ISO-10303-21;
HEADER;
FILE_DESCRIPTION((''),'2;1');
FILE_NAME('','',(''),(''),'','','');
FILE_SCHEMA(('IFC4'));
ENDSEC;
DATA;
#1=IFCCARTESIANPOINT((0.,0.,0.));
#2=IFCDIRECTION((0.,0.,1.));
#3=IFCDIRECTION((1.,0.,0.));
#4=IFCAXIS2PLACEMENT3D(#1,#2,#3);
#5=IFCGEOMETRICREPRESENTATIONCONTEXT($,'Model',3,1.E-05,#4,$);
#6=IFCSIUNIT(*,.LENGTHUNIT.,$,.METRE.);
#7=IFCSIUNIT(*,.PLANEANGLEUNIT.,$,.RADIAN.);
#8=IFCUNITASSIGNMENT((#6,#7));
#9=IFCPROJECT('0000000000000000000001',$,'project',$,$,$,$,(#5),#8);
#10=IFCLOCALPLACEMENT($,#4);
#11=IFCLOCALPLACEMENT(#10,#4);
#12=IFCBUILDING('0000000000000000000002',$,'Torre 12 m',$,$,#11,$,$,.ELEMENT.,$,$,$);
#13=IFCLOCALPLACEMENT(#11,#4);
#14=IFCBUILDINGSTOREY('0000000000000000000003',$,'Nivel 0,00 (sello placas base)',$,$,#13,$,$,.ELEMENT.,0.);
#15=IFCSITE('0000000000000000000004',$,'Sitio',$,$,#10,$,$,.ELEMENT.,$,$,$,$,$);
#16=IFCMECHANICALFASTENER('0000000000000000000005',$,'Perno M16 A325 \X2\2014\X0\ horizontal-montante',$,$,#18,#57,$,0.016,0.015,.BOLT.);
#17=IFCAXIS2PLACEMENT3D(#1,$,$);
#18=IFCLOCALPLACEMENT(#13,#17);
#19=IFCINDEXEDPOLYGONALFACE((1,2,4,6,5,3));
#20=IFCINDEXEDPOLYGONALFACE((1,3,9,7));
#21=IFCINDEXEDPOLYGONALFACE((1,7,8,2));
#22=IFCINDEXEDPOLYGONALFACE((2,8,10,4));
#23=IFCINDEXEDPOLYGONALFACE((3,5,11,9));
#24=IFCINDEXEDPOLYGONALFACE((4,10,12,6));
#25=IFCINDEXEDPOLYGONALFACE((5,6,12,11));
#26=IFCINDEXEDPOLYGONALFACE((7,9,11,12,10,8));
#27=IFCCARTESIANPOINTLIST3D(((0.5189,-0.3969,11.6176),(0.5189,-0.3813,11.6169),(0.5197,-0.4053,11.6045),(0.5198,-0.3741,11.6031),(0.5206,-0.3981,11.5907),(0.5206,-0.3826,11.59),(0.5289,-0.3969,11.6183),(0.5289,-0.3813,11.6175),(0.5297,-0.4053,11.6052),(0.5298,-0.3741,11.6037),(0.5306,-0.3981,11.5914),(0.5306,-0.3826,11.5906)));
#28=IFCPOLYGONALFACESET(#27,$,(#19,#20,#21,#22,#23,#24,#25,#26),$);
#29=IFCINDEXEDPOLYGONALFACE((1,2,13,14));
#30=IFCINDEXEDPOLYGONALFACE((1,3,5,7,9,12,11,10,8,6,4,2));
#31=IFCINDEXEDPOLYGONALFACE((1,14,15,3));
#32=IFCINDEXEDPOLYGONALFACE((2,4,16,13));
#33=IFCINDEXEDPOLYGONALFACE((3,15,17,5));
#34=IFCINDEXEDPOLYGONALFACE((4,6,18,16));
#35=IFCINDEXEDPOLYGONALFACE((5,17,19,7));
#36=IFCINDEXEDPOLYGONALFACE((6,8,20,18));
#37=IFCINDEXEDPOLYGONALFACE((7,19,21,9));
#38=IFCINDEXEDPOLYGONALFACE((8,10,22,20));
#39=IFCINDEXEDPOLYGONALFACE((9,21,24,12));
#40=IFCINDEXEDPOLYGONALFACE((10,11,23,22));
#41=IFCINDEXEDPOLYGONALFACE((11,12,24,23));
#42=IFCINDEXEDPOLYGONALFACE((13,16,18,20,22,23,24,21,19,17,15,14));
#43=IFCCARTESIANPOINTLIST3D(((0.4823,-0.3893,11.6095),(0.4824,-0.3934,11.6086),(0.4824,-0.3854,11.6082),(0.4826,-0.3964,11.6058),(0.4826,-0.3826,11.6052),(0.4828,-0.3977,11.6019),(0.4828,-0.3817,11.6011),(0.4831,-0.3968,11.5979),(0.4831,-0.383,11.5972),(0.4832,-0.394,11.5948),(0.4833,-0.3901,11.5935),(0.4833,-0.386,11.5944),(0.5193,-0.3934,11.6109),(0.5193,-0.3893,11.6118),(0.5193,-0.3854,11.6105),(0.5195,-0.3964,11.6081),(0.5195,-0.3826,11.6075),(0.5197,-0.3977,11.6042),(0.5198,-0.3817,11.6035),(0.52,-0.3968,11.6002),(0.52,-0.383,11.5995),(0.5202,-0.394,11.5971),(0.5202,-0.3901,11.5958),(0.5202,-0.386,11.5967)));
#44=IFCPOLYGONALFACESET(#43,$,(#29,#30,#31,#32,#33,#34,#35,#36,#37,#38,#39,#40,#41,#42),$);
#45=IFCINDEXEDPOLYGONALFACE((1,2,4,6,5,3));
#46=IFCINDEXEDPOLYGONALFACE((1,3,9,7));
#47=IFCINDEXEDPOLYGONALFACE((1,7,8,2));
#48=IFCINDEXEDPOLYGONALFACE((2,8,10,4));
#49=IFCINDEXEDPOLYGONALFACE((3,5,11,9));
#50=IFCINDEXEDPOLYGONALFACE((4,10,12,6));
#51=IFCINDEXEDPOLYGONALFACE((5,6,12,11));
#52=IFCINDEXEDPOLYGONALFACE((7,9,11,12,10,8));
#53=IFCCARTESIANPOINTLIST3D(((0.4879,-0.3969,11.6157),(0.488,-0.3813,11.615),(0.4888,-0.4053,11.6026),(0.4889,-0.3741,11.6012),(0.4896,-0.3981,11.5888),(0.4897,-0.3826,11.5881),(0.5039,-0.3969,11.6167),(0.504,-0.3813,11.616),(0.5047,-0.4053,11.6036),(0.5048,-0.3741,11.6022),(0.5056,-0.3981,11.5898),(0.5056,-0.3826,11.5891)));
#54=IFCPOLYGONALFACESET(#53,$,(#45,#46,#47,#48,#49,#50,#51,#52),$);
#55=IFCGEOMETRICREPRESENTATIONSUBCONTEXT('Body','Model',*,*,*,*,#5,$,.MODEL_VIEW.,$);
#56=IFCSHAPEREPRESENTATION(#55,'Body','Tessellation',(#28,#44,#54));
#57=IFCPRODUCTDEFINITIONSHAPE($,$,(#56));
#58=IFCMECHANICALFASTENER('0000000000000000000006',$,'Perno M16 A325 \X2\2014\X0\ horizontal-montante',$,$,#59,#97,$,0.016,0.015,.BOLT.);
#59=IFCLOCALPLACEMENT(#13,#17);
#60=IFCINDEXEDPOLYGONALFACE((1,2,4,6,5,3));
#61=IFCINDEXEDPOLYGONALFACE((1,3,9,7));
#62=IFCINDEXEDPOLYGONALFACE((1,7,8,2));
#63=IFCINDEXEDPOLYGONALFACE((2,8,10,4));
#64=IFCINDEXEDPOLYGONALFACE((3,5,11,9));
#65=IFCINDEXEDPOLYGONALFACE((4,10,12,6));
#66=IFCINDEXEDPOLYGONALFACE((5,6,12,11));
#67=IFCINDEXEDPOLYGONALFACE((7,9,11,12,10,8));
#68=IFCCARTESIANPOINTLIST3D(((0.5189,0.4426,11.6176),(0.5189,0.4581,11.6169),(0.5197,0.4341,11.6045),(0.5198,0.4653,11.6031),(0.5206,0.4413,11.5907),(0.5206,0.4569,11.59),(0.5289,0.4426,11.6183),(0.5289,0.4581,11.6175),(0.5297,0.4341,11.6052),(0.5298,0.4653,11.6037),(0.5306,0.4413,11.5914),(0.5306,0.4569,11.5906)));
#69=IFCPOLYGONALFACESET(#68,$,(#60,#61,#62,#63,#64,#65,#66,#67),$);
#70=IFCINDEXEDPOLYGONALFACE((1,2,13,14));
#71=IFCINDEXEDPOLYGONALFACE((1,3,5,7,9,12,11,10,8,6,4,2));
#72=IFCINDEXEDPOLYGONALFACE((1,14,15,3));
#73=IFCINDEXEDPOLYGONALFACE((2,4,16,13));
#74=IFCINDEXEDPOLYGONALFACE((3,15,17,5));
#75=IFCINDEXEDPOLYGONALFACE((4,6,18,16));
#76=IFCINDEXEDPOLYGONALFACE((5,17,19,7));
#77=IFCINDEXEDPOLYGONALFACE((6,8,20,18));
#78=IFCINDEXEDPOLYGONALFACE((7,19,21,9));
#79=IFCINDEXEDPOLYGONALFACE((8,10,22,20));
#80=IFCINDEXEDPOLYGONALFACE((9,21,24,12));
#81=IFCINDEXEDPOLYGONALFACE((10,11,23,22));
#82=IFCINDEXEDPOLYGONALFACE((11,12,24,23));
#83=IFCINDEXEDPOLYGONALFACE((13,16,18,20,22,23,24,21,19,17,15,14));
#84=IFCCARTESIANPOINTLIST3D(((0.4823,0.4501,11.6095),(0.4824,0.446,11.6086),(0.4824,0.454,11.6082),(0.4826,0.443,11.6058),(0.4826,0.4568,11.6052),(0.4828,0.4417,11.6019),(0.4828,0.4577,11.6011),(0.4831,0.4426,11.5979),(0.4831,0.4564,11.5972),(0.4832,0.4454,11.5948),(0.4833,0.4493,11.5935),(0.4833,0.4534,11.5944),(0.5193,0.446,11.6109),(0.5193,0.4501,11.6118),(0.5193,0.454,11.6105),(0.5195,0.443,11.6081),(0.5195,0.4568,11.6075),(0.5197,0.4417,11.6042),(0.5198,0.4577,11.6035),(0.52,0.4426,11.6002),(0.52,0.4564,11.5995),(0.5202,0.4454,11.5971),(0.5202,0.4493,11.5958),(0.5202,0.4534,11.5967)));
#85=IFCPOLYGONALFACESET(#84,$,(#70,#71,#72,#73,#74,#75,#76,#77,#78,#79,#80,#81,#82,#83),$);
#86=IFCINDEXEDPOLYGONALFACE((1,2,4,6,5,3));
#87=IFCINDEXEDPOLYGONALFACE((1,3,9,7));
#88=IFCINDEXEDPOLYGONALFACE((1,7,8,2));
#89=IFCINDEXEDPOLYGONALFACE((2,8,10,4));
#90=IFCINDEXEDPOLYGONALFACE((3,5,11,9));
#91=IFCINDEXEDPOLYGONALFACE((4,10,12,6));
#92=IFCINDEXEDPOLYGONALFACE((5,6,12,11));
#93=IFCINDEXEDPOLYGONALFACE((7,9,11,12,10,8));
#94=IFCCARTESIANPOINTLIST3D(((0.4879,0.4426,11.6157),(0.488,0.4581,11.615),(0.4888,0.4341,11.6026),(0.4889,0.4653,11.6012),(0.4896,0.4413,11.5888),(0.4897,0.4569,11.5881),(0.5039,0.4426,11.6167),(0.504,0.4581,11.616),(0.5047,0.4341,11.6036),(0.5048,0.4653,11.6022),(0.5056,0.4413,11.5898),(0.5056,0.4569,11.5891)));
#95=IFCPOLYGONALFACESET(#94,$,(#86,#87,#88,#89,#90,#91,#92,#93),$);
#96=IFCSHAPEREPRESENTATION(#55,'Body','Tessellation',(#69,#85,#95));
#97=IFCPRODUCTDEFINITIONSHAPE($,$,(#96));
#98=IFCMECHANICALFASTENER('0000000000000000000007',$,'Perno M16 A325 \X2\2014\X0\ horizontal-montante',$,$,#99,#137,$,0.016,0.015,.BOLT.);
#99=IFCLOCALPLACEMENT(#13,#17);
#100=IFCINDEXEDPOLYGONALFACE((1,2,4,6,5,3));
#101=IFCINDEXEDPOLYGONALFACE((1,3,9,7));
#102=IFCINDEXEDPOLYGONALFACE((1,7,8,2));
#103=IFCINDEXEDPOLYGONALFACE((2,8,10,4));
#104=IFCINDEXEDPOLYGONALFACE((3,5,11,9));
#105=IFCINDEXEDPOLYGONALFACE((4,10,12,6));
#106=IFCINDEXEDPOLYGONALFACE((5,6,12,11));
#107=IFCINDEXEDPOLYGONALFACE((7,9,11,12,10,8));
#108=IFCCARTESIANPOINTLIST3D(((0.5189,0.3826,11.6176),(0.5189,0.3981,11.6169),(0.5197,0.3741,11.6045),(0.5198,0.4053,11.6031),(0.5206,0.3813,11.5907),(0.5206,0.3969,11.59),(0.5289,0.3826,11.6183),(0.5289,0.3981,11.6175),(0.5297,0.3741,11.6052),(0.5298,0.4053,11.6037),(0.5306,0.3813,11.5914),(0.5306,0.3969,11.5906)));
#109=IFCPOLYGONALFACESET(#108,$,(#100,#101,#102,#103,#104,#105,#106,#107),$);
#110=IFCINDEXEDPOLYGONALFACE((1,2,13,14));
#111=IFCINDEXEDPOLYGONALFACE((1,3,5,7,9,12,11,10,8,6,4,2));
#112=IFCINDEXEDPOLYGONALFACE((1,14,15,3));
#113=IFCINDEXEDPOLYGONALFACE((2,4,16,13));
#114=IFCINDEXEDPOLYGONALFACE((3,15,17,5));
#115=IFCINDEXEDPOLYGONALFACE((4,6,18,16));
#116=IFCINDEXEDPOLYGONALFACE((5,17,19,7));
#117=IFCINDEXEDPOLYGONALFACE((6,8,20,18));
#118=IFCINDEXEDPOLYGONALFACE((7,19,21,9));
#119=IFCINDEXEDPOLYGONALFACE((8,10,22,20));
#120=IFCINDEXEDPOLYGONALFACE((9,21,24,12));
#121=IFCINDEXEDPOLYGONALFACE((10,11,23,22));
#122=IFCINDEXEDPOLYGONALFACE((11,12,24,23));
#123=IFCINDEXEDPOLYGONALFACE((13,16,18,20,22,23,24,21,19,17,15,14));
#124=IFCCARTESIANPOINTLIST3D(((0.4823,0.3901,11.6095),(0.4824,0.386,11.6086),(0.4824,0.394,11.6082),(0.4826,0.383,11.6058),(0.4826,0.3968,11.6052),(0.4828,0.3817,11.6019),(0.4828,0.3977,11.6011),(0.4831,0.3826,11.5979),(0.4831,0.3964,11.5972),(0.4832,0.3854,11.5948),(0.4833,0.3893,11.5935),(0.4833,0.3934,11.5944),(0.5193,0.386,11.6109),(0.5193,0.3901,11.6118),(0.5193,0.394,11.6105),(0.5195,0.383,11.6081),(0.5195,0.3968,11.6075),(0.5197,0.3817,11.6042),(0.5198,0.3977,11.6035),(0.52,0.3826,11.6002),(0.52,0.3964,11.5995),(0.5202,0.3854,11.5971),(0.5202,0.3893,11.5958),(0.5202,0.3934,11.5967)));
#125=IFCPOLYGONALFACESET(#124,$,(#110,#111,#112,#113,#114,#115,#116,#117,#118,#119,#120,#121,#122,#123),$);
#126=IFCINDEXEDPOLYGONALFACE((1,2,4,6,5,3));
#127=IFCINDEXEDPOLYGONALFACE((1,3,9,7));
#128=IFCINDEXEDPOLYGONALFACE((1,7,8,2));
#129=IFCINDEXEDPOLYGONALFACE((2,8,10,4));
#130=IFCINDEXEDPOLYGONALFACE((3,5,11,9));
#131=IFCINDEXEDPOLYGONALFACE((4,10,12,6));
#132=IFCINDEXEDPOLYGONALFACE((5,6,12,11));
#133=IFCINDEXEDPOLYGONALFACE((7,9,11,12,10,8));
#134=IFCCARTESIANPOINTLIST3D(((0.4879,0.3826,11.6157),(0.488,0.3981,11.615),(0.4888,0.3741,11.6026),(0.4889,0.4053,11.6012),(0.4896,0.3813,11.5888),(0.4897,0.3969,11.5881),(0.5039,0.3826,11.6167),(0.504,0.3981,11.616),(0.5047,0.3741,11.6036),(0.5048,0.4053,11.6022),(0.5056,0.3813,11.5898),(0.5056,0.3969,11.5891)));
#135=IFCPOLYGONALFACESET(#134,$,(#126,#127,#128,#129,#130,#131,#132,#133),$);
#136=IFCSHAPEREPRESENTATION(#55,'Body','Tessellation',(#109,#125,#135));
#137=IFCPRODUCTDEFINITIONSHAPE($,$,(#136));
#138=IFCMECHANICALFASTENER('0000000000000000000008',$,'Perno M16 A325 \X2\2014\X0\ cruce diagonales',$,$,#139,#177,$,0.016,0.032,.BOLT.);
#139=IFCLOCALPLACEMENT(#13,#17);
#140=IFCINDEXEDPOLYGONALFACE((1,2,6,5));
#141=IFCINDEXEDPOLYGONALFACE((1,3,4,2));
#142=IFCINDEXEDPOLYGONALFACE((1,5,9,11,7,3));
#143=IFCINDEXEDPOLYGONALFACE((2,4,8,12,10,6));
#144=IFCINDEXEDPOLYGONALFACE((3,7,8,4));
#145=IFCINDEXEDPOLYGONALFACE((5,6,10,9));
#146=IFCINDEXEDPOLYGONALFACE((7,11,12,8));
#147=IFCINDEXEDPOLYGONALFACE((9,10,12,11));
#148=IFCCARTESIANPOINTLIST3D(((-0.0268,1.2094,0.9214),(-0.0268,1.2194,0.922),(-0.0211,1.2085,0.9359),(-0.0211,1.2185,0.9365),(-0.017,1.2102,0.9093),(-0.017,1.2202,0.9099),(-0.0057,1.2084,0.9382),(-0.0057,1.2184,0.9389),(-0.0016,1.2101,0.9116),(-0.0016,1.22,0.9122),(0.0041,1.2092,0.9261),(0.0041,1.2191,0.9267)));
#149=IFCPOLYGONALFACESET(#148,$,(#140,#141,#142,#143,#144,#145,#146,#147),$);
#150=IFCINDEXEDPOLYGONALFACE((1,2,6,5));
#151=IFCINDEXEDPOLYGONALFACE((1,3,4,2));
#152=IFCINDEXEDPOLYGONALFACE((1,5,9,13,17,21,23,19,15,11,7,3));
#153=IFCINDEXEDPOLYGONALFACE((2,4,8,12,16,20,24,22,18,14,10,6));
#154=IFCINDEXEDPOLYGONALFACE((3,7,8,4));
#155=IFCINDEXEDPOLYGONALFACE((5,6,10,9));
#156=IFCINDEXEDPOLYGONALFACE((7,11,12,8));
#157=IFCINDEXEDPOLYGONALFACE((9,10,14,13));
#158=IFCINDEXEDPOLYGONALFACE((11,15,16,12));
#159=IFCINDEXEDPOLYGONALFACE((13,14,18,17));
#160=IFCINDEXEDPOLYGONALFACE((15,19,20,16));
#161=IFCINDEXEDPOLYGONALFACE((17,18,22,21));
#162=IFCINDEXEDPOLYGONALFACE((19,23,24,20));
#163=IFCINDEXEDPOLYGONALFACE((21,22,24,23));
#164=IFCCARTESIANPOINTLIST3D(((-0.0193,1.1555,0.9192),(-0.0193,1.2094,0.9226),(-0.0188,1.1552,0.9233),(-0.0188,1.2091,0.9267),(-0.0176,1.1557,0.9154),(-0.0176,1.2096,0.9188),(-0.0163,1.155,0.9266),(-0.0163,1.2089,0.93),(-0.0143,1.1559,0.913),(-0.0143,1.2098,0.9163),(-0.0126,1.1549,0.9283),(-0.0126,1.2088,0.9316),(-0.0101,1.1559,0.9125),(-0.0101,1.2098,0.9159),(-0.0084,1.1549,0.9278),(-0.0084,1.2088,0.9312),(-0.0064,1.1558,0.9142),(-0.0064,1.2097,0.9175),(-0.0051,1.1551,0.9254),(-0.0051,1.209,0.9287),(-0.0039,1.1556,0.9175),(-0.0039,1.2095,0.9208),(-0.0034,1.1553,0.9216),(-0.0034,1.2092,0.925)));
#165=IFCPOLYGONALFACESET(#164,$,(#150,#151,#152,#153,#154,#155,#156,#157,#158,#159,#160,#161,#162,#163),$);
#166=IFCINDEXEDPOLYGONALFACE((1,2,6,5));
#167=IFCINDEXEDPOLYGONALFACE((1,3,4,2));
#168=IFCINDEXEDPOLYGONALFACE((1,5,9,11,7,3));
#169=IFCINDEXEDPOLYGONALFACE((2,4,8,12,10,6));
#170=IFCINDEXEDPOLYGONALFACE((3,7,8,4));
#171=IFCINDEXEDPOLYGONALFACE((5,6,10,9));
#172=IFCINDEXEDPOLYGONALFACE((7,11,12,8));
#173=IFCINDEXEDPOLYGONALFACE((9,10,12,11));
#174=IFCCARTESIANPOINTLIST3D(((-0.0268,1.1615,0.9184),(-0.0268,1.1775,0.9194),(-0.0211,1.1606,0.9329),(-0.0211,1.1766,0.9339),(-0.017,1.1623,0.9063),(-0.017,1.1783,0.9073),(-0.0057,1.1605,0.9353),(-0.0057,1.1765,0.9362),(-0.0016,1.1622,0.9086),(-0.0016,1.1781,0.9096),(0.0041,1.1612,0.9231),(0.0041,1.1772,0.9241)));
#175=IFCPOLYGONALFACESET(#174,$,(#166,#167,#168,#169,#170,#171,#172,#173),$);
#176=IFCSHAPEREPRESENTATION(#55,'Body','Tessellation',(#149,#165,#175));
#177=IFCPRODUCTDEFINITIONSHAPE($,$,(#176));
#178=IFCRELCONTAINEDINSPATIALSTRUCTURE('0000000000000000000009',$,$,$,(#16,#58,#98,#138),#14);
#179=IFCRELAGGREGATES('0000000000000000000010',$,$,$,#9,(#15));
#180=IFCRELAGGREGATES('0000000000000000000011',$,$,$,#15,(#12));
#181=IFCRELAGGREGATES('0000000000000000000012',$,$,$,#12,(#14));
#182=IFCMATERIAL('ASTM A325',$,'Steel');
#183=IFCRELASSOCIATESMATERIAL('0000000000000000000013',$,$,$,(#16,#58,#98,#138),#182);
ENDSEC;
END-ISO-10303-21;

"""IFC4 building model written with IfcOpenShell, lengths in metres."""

from ifc_helpers import new_model, si_unit, frame, origin_with_axes, place, context, subcontext, project, spatial, polyline, outline, extrude, material, element, save


model = new_model("IFC4")

# Units and contexts
model_context = context("Model", 3, precision=1e-05, world=origin_with_axes())
body_context = subcontext(model_context, "Body", "Model", "MODEL_VIEW")
ifc_project = project(units=[si_unit("LENGTHUNIT", "METRE"), si_unit("PLANEANGLEUNIT", "RADIAN")], contexts=[model_context])

# Site, building, storey
site_placement = place(None, origin_with_axes())
site = spatial("IfcSite", under=ifc_project, at=site_placement, Name="Sitio", CompositionType="ELEMENT")
building_placement = place(site_placement, origin_with_axes())
building = spatial("IfcBuilding", under=site, at=building_placement, Name="Torre 12 m", CompositionType="ELEMENT")
storey_placement = place(building_placement, origin_with_axes())
storey = spatial("IfcBuildingStorey", under=building, at=storey_placement, Name="Nivel 0,00 (sello placas base)", CompositionType="ELEMENT", Elevation=0.0)

# Shared definitions
placement = place(storey_placement, origin_with_axes())

# Mechanical fasteners
ifc_material_1 = material(Name="ASTM A325", Category="Steel")
element("IfcMechanicalFastener", 1, at=placement, inside=storey, material=ifc_material_1, Name="Perno M16 A325 — horizontal-montante", NominalDiameter=0.016, NominalLength=0.015, PredefinedType="BOLT", context=body_context, shape_type="SweptSolid", body=[
    extrude(outline(polyline([(0.0135, 0.0078), (0.0, 0.0156), (-0.0135, 0.0078), (-0.0135, -0.0078), (0.0, -0.0156), (0.0135, -0.0078), (0.0135, 0.0078)])), frame((0.5297, -0.3897, 11.6044), z_axis=(-0.998053, 0.0, -0.062378), x_axis=(0.033672, 0.841794, -0.538748)), (0.0, 0.0, 1.0), 0.01),
    extrude(outline(polyline([(0.008, 0.0), (0.0069, 0.004), (0.004, 0.0069), (0.0, 0.008), (-0.004, 0.0069), (-0.0069, 0.004), (-0.008, 0.0), (-0.0069, -0.004), (-0.004, -0.0069), (0.0, -0.008), (0.004, -0.0069), (0.0069, -0.004), (0.008, 0.0)])), frame((0.5198, -0.3897, 11.6038), z_axis=(-0.998053, 0.0, -0.062378), x_axis=(0.033672, 0.841794, -0.538748)), (0.0, 0.0, 1.0), 0.037),
    extrude(outline(polyline([(0.0135, 0.0078), (0.0, 0.0156), (-0.0135, 0.0078), (-0.0135, -0.0078), (0.0, -0.0156), (0.0135, -0.0078), (0.0135, 0.0078)])), frame((0.5048, -0.3897, 11.6029), z_axis=(-0.998053, 0.0, -0.062378), x_axis=(0.033672, 0.841794, -0.538748)), (0.0, 0.0, 1.0), 0.016),
])
element("IfcMechanicalFastener", 2, at=placement, inside=storey, material=ifc_material_1, Name="Perno M16 A325 — horizontal-montante", NominalDiameter=0.016, NominalLength=0.015, PredefinedType="BOLT", context=body_context, shape_type="SweptSolid", body=[
    extrude(outline(polyline([(0.0135, 0.0078), (0.0, 0.0156), (-0.0135, 0.0078), (-0.0135, -0.0078), (0.0, -0.0156), (0.0135, -0.0078), (0.0135, 0.0078)])), frame((0.5297, 0.4497, 11.6044), z_axis=(-0.998053, 0.0, -0.062378), x_axis=(0.033672, 0.841794, -0.538748)), (0.0, 0.0, 1.0), 0.01),
    extrude(outline(polyline([(0.008, 0.0), (0.0069, 0.004), (0.004, 0.0069), (0.0, 0.008), (-0.004, 0.0069), (-0.0069, 0.004), (-0.008, 0.0), (-0.0069, -0.004), (-0.004, -0.0069), (0.0, -0.008), (0.004, -0.0069), (0.0069, -0.004), (0.008, 0.0)])), frame((0.5198, 0.4497, 11.6038), z_axis=(-0.998053, 0.0, -0.062378), x_axis=(0.033672, 0.841794, -0.538748)), (0.0, 0.0, 1.0), 0.037),
    extrude(outline(polyline([(0.0135, 0.0078), (0.0, 0.0156), (-0.0135, 0.0078), (-0.0135, -0.0078), (0.0, -0.0156), (0.0135, -0.0078), (0.0135, 0.0078)])), frame((0.5048, 0.4497, 11.6029), z_axis=(-0.998053, 0.0, -0.062378), x_axis=(0.033672, 0.841794, -0.538748)), (0.0, 0.0, 1.0), 0.016),
])
element("IfcMechanicalFastener", 3, at=placement, inside=storey, material=ifc_material_1, Name="Perno M16 A325 — horizontal-montante", NominalDiameter=0.016, NominalLength=0.015, PredefinedType="BOLT", context=body_context, shape_type="SweptSolid", body=[
    extrude(outline(polyline([(0.0135, 0.0078), (0.0, 0.0156), (-0.0135, 0.0078), (-0.0135, -0.0078), (0.0, -0.0156), (0.0135, -0.0078), (0.0135, 0.0078)])), frame((0.5297, 0.3897, 11.6044), z_axis=(-0.998053, 0.0, -0.062378), x_axis=(0.033672, 0.841794, -0.538748)), (0.0, 0.0, 1.0), 0.01),
    extrude(outline(polyline([(0.008, 0.0), (0.0069, 0.004), (0.004, 0.0069), (0.0, 0.008), (-0.004, 0.0069), (-0.0069, 0.004), (-0.008, 0.0), (-0.0069, -0.004), (-0.004, -0.0069), (0.0, -0.008), (0.004, -0.0069), (0.0069, -0.004), (0.008, 0.0)])), frame((0.5198, 0.3897, 11.6038), z_axis=(-0.998053, 0.0, -0.062378), x_axis=(0.033672, 0.841794, -0.538748)), (0.0, 0.0, 1.0), 0.037),
    extrude(outline(polyline([(0.0135, 0.0078), (0.0, 0.0156), (-0.0135, 0.0078), (-0.0135, -0.0078), (0.0, -0.0156), (0.0135, -0.0078), (0.0135, 0.0078)])), frame((0.5048, 0.3897, 11.6029), z_axis=(-0.998053, 0.0, -0.062378), x_axis=(0.033672, 0.841794, -0.538748)), (0.0, 0.0, 1.0), 0.016),
])
element("IfcMechanicalFastener", 4, at=placement, inside=storey, material=ifc_material_1, Name="Perno M16 A325 — cruce diagonales", NominalDiameter=0.016, NominalLength=0.032, PredefinedType="BOLT", context=body_context, shape_type="SweptSolid", body=[
    extrude(outline(polyline([(0.0135, 0.0078), (0.0, 0.0156), (-0.0135, 0.0078), (-0.0135, -0.0078), (0.0, -0.0156), (0.0135, -0.0078), (0.0135, 0.0078)])), frame((-0.0113, 1.2193, 0.9244), z_axis=(0.0, -0.998053, -0.062378), x_axis=(-0.931337, -0.022716, 0.363449)), (0.0, 0.0, 1.0), 0.01),
    extrude(outline(polyline([(0.008, 0.0), (0.0069, 0.004), (0.004, 0.0069), (0.0, 0.008), (-0.004, 0.0069), (-0.0069, 0.004), (-0.008, 0.0), (-0.0069, -0.004), (-0.004, -0.0069), (0.0, -0.008), (0.004, -0.0069), (0.0069, -0.004), (0.008, 0.0)])), frame((-0.0113, 1.2093, 0.9238), z_axis=(0.0, -0.998053, -0.062378), x_axis=(-0.931337, -0.022716, 0.363449)), (0.0, 0.0, 1.0), 0.054),
    extrude(outline(polyline([(0.0135, 0.0078), (0.0, 0.0156), (-0.0135, 0.0078), (-0.0135, -0.0078), (0.0, -0.0156), (0.0135, -0.0078), (0.0135, 0.0078)])), frame((-0.0113, 1.1774, 0.9218), z_axis=(0.0, -0.998053, -0.062378), x_axis=(-0.931337, -0.022716, 0.363449)), (0.0, 0.0, 1.0), 0.016),
])

save(model, "model.ifc")
